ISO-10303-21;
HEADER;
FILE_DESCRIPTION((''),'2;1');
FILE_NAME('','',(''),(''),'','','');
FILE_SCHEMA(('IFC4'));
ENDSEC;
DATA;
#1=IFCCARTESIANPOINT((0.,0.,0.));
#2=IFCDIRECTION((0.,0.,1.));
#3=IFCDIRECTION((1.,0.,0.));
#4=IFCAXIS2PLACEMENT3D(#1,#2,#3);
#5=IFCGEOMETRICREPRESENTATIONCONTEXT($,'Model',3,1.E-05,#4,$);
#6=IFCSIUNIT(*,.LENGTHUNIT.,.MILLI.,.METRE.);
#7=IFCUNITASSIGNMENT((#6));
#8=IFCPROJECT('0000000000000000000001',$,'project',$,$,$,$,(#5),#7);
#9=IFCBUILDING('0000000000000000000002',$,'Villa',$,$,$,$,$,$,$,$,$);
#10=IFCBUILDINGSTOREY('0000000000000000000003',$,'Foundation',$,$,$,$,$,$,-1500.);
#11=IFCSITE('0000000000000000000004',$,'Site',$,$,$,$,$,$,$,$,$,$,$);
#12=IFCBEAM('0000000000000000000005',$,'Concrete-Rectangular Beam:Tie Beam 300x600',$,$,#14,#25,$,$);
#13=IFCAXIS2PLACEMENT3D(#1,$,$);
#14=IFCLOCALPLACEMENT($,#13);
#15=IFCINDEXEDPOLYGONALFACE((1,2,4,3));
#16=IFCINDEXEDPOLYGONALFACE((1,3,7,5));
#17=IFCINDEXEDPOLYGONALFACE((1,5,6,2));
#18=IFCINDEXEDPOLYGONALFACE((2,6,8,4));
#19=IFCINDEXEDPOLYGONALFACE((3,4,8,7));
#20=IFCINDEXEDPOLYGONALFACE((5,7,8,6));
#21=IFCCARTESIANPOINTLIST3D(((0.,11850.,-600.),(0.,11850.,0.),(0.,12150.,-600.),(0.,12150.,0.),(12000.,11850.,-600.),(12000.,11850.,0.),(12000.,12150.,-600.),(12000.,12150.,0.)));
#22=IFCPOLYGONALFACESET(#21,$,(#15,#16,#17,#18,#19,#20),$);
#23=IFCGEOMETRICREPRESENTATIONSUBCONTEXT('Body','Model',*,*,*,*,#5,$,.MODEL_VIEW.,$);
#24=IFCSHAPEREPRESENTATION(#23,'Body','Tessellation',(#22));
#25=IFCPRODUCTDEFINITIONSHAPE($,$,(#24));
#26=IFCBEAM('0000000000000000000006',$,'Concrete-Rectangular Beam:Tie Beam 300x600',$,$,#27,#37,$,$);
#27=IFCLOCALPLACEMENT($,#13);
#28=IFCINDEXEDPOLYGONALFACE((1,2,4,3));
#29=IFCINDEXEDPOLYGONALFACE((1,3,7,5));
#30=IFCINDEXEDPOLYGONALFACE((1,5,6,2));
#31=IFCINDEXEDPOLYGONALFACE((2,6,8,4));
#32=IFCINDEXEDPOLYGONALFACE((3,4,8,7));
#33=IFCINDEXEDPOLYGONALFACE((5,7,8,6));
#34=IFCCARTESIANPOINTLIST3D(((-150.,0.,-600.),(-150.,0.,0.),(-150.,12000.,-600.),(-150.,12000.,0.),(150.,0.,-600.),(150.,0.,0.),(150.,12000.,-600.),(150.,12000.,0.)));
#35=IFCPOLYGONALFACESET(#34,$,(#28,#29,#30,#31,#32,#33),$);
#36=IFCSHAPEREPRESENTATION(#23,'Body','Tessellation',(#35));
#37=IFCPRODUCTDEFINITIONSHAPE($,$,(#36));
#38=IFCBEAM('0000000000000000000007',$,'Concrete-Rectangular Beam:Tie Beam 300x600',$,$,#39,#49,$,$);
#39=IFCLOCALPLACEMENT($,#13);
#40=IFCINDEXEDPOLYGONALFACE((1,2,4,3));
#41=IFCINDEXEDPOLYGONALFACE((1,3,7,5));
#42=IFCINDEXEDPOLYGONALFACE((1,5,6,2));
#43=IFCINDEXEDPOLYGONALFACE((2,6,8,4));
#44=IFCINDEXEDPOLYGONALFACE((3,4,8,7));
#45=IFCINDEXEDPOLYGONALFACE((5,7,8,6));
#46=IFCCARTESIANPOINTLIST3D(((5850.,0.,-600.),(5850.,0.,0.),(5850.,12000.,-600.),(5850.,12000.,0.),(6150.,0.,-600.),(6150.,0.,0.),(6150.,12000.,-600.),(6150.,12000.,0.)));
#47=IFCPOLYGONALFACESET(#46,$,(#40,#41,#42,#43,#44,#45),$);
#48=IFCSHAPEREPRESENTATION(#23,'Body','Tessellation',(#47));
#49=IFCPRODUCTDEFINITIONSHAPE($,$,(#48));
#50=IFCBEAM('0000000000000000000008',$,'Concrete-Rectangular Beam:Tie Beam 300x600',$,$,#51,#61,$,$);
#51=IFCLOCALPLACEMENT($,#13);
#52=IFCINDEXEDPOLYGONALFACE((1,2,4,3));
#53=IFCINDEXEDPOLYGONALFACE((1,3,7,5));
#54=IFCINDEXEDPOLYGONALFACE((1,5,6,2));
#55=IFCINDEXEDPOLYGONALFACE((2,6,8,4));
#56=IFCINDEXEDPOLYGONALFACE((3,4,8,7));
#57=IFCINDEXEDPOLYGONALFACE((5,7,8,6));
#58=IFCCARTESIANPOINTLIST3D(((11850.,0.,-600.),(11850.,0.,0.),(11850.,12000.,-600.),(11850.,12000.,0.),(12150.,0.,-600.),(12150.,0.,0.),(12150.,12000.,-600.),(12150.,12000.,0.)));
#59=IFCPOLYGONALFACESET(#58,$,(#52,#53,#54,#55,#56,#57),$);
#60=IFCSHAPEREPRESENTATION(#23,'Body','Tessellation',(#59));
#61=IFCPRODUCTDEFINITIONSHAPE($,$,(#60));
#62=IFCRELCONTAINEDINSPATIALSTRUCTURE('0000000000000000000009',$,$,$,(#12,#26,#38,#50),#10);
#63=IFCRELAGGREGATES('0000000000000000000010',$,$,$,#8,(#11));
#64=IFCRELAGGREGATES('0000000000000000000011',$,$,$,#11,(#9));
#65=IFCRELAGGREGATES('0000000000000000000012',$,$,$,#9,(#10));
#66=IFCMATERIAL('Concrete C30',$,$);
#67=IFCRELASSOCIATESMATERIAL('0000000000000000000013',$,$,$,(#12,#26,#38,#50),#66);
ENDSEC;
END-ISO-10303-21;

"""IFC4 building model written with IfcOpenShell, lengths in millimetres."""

from ifc_helpers import new_model, si_unit, frame, origin_with_axes, place, context, subcontext, project, spatial, indexed_curve, outline, extrude, material, element, save


model = new_model("IFC4")

# Units and contexts
model_context = context("Model", 3, precision=1e-05, world=origin_with_axes())
body_context = subcontext(model_context, "Body", "Model", "MODEL_VIEW")
ifc_project = project(units=[si_unit("LENGTHUNIT", "METRE", prefix="MILLI")], contexts=[model_context])

# Site, building, storey
site = spatial("IfcSite", under=ifc_project, Name="Site")
building = spatial("IfcBuilding", under=site, Name="Villa")
storey = spatial("IfcBuildingStorey", under=building, Name="Foundation", Elevation=-1500.0)

# Shared definitions
ifc_material = material(Name="Concrete C30")

# Beams
for number, where, z_axis, x_axis, name in (
    (1, (0.0, 11850.0, -600.0), (0.0, 0.0, 1.0), (1.0, 0.0, 0.0), "Concrete-Rectangular Beam:Tie Beam 300x600"),
    (2, (150.0, 0.0, -600.0), (0.0, 0.0, 1.0), (0.0, 1.0, 0.0), "Concrete-Rectangular Beam:Tie Beam 300x600"),
    (3, (6150.0, 0.0, -600.0), (0.0, 0.0, 1.0), (0.0, 1.0, 0.0), "Concrete-Rectangular Beam:Tie Beam 300x600"),
    (4, (12150.0, 0.0, -600.0), (0.0, 0.0, 1.0), (0.0, 1.0, 0.0), "Concrete-Rectangular Beam:Tie Beam 300x600"),
):
    element("IfcBeam", number, at=place(None, frame(where, z_axis=z_axis, x_axis=x_axis)), inside=storey, material=ifc_material, Name=name, context=body_context, shape_type="SweptSolid", body=[
        extrude(outline(indexed_curve([(0.0, 0.0), (0.0, 300.0), (12000.0, 300.0), (12000.0, 0.0), (0.0, 0.0)], self_intersect=False)), origin_with_axes(), (0.0, 0.0, 1.0), 600.0),
    ])

save(model, "model.ifc")
